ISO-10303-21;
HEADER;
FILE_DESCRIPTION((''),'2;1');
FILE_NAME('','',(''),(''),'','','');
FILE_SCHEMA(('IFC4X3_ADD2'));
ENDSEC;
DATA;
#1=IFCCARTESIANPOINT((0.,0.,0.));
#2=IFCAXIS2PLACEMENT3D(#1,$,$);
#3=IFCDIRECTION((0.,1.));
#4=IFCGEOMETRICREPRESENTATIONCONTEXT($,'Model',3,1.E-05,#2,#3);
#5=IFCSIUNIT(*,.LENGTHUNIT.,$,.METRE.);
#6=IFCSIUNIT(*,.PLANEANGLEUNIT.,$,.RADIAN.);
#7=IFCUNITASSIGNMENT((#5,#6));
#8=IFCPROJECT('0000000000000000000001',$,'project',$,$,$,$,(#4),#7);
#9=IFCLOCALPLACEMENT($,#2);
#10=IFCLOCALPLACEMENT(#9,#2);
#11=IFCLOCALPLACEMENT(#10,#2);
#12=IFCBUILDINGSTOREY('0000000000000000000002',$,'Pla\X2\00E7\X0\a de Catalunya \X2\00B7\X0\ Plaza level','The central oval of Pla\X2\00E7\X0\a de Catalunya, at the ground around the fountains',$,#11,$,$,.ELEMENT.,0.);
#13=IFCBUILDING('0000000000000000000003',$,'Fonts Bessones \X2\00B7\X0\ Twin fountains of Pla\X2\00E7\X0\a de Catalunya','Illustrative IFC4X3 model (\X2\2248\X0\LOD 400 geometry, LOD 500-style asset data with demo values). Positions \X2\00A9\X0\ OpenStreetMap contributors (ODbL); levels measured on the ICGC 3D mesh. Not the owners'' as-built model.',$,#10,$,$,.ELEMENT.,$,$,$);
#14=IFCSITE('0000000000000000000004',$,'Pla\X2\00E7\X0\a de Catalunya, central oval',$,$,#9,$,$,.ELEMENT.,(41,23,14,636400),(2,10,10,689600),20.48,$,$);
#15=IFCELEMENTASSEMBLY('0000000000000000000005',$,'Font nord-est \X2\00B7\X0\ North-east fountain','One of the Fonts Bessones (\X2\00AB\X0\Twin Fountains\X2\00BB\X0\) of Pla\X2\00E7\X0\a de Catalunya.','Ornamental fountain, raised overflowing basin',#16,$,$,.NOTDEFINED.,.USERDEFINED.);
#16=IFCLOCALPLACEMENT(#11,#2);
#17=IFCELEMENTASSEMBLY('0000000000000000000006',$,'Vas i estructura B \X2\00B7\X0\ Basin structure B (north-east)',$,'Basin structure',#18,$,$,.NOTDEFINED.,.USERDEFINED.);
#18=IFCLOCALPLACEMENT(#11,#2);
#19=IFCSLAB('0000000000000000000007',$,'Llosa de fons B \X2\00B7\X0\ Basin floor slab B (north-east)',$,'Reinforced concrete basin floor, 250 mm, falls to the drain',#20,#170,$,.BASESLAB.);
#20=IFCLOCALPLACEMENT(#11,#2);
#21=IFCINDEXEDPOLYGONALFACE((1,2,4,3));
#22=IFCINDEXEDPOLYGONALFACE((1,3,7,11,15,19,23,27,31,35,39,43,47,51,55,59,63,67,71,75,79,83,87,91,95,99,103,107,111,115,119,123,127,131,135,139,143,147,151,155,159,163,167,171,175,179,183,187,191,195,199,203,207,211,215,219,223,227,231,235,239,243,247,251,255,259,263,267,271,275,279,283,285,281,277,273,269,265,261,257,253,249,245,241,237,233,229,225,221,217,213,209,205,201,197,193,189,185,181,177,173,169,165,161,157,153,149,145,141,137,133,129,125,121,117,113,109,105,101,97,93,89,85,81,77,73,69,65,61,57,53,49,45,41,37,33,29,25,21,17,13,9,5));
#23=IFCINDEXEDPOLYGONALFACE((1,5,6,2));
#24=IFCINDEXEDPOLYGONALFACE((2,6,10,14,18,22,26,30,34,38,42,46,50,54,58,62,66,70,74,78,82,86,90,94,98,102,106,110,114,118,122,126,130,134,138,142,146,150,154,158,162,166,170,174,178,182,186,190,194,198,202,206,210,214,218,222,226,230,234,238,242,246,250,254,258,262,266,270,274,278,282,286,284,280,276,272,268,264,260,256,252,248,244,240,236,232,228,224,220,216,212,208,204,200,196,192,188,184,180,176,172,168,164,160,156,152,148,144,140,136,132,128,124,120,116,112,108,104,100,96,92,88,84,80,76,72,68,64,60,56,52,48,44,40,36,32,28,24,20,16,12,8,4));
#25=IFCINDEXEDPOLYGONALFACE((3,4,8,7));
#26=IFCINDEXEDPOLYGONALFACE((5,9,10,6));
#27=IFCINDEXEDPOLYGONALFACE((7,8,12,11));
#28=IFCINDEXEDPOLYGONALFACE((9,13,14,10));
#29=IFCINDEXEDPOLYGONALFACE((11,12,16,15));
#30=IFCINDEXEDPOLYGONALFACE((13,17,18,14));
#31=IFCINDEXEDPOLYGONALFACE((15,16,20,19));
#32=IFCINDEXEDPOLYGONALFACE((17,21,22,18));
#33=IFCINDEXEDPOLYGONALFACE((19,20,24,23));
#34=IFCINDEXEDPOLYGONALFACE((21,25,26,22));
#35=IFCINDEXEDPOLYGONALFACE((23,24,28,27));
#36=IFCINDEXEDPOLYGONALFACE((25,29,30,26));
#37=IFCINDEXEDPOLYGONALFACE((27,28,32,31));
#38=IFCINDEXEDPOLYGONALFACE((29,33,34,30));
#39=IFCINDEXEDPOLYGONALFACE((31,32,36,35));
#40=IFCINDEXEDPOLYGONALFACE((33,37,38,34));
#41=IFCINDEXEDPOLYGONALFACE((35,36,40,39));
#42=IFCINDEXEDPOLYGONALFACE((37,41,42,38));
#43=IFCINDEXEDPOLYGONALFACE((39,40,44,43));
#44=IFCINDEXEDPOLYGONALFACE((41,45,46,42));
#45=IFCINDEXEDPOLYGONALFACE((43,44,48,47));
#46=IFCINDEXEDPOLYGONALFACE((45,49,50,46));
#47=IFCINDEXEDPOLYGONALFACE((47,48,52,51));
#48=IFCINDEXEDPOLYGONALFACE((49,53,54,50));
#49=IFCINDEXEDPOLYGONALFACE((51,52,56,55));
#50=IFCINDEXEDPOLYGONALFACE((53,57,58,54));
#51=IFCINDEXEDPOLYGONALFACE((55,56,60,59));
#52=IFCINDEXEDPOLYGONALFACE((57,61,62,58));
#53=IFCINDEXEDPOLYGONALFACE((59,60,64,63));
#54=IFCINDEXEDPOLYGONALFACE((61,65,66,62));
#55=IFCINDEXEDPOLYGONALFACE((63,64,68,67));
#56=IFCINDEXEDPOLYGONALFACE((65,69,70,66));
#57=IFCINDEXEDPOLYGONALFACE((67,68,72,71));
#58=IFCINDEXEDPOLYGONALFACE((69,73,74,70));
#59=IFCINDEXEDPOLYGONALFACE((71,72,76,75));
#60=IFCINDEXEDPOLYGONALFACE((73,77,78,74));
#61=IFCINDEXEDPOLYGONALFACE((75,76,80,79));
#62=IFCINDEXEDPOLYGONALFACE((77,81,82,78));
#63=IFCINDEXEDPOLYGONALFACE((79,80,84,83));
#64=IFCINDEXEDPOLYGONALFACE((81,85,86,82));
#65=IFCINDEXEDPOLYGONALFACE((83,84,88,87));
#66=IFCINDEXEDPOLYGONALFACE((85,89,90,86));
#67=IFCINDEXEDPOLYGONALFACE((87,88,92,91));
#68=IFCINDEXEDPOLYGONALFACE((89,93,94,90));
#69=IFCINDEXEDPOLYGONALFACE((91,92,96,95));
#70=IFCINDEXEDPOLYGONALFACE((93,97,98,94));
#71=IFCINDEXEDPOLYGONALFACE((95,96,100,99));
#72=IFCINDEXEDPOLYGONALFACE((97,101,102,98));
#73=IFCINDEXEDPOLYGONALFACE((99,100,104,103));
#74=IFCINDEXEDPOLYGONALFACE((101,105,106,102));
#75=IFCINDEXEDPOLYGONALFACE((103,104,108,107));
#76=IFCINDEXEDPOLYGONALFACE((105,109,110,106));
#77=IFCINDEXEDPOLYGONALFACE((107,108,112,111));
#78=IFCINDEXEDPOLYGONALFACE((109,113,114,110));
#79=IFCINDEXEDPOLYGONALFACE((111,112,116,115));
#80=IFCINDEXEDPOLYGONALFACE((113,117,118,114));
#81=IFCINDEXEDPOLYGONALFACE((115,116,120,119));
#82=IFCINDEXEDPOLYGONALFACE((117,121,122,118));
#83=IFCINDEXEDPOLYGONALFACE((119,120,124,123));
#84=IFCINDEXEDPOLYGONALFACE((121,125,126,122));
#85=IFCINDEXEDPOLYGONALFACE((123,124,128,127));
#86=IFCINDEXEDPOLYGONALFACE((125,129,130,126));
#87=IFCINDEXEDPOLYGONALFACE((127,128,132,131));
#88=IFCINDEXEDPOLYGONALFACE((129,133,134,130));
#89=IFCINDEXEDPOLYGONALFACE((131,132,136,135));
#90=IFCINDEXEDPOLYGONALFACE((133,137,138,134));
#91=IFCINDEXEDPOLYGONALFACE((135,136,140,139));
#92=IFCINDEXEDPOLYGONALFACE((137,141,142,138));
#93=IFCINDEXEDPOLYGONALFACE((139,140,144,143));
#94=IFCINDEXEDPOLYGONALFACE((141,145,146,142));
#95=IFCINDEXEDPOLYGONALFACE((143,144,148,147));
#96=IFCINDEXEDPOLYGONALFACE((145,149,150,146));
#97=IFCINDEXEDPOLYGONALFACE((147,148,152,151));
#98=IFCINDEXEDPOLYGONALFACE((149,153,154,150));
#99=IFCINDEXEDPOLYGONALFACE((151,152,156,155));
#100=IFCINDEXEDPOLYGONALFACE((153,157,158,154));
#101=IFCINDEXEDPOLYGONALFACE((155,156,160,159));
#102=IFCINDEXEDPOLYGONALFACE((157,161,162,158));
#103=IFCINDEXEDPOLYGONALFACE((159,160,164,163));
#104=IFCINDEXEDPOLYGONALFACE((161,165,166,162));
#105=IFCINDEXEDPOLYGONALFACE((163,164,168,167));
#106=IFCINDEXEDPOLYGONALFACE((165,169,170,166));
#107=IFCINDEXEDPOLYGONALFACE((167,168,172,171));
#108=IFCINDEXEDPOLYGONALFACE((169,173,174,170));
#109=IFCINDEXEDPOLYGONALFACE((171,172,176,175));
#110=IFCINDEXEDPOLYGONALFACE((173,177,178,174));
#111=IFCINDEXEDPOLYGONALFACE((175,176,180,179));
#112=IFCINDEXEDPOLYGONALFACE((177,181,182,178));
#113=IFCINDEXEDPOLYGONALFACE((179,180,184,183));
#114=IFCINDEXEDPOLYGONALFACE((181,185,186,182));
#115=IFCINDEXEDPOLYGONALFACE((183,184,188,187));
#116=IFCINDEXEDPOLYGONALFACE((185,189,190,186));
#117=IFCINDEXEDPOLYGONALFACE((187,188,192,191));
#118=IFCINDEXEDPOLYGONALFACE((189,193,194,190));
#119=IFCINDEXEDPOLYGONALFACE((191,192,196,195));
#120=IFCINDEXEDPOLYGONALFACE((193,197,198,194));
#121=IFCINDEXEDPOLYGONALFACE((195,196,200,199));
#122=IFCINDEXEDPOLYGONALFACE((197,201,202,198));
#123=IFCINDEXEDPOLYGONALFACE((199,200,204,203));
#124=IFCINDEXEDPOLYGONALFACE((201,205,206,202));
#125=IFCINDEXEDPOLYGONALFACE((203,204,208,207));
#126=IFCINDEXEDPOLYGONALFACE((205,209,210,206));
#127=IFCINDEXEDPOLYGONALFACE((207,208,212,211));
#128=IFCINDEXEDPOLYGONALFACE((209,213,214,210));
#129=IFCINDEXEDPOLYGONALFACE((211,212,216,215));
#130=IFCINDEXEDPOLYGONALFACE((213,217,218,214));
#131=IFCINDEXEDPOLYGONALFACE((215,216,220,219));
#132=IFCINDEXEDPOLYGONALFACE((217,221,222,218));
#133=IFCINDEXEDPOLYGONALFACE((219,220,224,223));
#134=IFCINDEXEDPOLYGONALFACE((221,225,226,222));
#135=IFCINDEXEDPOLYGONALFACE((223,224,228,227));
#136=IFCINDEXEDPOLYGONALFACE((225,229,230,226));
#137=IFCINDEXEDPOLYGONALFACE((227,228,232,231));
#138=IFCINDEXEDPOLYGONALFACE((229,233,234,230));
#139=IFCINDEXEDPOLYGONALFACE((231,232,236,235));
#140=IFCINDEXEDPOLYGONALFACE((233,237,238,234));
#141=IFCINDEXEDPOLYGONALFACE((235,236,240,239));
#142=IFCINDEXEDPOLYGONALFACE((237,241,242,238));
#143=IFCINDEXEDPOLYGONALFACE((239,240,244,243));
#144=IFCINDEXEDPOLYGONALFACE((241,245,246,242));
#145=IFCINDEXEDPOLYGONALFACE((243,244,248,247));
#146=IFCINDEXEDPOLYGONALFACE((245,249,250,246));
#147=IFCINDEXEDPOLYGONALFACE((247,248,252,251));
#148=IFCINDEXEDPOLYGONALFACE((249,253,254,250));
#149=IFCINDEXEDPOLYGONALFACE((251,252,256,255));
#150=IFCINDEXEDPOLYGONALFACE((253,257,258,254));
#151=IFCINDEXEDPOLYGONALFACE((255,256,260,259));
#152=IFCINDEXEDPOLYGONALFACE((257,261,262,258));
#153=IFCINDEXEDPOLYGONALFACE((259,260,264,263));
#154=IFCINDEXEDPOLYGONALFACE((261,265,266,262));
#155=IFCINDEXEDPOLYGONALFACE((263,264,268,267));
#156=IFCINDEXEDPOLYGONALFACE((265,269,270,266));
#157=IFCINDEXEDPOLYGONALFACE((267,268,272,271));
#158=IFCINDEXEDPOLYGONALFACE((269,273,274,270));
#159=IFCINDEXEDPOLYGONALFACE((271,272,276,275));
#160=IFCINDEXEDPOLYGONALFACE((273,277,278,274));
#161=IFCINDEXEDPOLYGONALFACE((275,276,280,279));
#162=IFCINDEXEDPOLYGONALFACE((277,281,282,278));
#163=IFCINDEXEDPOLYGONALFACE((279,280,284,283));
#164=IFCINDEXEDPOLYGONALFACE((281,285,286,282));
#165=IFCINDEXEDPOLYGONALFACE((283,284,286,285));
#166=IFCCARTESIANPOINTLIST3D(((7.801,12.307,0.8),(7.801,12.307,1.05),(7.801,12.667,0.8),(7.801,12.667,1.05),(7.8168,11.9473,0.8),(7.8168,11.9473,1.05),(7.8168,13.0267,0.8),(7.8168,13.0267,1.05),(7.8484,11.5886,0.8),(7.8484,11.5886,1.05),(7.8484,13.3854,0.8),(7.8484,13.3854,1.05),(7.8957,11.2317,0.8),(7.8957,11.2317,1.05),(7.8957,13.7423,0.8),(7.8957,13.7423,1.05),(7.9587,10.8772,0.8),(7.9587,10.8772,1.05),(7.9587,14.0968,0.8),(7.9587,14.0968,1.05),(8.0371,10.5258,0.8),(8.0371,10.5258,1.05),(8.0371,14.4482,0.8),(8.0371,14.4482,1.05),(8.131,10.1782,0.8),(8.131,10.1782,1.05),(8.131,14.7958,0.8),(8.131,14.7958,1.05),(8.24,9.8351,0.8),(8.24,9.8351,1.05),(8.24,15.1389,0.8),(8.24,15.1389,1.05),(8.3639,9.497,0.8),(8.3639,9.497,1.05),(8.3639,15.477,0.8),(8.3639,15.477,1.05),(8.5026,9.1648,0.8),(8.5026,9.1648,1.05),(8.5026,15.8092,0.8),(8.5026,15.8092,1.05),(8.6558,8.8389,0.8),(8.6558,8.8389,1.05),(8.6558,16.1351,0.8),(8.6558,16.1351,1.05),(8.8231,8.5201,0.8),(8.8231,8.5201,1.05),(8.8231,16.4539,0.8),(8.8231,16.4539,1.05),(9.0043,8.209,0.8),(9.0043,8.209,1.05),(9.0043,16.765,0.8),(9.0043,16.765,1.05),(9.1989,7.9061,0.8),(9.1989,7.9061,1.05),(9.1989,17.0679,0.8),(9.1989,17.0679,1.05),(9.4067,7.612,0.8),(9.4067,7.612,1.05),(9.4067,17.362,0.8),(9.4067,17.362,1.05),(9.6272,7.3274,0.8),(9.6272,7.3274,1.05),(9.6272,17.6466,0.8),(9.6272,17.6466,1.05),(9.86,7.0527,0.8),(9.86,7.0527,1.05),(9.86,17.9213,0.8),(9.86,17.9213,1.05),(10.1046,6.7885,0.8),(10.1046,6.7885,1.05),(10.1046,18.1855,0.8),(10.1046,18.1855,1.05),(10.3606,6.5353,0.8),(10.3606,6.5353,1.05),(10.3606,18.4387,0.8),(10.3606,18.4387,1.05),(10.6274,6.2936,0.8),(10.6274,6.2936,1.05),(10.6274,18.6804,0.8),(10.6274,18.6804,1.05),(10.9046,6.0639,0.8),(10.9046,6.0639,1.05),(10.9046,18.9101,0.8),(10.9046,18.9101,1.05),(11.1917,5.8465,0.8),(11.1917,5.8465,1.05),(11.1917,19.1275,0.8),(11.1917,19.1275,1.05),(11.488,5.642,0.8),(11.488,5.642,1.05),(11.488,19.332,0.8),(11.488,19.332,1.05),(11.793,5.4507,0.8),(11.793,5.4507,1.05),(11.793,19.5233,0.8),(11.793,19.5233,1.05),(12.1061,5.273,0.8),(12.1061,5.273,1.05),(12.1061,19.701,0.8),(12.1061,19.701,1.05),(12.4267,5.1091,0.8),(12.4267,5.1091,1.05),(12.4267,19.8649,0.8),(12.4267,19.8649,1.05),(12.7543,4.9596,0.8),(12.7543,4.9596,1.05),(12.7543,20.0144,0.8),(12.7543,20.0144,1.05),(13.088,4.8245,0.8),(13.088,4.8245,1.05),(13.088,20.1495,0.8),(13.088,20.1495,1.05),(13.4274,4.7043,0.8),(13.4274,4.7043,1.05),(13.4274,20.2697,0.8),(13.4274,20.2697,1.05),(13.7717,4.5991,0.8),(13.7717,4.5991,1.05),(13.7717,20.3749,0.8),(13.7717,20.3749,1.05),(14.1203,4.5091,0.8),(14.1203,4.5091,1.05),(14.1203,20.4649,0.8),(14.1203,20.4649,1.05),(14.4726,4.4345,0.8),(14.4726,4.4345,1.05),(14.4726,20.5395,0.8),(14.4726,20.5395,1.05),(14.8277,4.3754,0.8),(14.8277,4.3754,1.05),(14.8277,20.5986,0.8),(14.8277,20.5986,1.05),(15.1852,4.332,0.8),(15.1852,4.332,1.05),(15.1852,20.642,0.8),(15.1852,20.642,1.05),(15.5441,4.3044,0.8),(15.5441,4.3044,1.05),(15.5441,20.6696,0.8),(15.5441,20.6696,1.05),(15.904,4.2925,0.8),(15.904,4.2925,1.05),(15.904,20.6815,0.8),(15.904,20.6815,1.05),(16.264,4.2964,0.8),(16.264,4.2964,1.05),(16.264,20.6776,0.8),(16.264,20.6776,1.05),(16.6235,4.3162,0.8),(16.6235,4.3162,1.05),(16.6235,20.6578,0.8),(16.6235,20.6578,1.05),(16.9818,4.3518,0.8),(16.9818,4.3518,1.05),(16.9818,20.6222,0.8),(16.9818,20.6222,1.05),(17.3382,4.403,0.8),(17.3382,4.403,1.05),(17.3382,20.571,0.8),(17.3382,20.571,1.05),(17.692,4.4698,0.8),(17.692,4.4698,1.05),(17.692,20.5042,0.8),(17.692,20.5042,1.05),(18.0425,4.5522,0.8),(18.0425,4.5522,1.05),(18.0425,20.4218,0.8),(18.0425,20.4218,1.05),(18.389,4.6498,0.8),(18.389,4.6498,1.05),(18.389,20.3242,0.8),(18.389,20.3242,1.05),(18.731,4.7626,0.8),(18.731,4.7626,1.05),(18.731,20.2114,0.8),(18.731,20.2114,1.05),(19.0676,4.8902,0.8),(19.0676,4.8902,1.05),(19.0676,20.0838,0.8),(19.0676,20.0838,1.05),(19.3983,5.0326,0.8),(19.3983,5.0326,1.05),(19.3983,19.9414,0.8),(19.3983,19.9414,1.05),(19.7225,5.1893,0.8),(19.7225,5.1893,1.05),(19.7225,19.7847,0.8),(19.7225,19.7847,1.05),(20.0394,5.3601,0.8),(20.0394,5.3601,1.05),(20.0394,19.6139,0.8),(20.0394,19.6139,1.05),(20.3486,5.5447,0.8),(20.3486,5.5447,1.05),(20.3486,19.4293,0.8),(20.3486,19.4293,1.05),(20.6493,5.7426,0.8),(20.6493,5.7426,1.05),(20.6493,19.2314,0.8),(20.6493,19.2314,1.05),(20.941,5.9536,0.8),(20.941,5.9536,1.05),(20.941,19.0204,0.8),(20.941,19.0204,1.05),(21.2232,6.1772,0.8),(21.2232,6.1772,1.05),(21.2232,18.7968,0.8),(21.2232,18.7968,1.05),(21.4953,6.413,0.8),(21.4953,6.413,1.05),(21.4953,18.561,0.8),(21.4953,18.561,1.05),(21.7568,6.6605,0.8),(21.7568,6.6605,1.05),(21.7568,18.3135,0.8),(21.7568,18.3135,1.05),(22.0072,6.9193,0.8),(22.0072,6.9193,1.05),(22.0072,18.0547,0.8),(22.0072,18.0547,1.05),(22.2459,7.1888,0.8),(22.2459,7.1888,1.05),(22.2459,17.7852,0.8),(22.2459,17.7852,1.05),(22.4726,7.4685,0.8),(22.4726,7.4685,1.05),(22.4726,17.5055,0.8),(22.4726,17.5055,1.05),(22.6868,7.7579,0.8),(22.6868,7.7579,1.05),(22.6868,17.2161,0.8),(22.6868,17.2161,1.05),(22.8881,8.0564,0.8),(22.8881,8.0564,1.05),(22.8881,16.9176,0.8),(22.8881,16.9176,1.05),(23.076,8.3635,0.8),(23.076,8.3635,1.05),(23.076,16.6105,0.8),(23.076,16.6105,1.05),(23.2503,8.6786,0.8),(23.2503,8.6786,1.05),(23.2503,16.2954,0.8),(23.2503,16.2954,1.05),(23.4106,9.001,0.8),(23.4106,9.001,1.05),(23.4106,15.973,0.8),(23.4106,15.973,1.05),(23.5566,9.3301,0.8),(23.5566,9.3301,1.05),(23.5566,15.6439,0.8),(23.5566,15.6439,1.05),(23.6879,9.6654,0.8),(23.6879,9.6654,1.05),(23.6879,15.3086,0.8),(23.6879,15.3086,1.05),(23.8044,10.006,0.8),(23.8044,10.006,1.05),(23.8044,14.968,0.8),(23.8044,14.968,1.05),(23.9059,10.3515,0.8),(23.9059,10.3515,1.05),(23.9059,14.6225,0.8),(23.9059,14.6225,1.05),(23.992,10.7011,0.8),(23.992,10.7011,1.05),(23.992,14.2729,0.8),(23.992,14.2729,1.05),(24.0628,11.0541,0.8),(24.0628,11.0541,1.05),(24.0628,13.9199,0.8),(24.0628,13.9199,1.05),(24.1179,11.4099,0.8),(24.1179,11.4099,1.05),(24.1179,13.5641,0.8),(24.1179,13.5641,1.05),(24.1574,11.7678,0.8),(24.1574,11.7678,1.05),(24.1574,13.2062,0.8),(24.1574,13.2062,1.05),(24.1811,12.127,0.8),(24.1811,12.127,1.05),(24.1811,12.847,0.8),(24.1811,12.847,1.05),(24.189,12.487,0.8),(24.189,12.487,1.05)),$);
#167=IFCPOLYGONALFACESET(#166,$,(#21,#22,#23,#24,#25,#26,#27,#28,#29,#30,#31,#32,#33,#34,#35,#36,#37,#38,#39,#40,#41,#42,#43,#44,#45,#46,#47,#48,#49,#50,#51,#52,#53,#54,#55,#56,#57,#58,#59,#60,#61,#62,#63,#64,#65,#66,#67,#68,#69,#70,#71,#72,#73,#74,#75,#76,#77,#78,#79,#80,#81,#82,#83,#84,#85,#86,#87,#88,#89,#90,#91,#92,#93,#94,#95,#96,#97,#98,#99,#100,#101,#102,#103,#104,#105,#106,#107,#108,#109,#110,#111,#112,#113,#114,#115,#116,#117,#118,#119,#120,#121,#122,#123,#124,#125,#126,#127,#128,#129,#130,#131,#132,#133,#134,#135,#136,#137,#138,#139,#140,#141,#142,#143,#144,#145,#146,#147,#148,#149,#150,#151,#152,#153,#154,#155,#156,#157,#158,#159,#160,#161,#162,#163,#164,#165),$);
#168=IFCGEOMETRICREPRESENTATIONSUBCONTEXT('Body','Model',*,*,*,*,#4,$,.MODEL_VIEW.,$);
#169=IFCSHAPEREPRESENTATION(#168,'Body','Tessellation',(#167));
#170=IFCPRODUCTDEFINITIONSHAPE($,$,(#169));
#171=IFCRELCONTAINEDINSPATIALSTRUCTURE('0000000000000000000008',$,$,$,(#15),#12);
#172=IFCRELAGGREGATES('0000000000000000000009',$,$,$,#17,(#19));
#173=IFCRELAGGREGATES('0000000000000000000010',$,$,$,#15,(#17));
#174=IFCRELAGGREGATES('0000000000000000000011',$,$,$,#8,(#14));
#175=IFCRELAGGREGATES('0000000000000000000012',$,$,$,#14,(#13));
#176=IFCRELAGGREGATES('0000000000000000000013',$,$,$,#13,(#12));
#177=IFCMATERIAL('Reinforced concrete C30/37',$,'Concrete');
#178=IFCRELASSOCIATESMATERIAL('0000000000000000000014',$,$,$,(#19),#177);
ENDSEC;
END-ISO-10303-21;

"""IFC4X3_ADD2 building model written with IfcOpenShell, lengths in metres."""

from ifc_helpers import new_model, si_unit, direction, frame, origin, origin_2d_with_axis, place, context, subcontext, project, spatial, circle, extrude, material, element, aggregate, save


model = new_model("IFC4X3_ADD2")

# Units and contexts
model_context = context("Model", 3, precision=1e-05, world=origin(), true_north=direction((0.0, 1.0)))
body_context = subcontext(model_context, "Body", "Model", "MODEL_VIEW")
ifc_project = project(units=[si_unit("LENGTHUNIT", "METRE"), si_unit("PLANEANGLEUNIT", "RADIAN")], contexts=[model_context])

# Site, building, storey
site_placement = place(None, origin())
site = spatial("IfcSite", under=ifc_project, at=site_placement, Name="Plaça de Catalunya, central oval", CompositionType="ELEMENT", RefLatitude=(41, 23, 14, 636400), RefLongitude=(2, 10, 10, 689600), RefElevation=20.48)
building_placement = place(site_placement, origin())
building = spatial("IfcBuilding", under=site, at=building_placement, Name="Fonts Bessones · Twin fountains of Plaça de Catalunya", Description="Illustrative IFC4X3 model (≈LOD 400 geometry, LOD 500-style asset data with demo values). Positions © OpenStreetMap contributors (ODbL); levels measured on the ICGC 3D mesh. Not the owners' as-built model.", CompositionType="ELEMENT")
storey_placement = place(building_placement, origin())
storey = spatial("IfcBuildingStorey", under=building, at=storey_placement, Name="Plaça de Catalunya · Plaza level", Description="The central oval of Plaça de Catalunya, at the ground around the fountains", CompositionType="ELEMENT", Elevation=0.0)

# Element assemblies
assembly_1_placement = place(building_placement, origin())
assembly_1 = element("IfcElementAssembly", 1, at=assembly_1_placement, inside=storey, Name="Font nord-est · North-east fountain", Description="One of the Fonts Bessones («Twin Fountains») of Plaça de Catalunya.", ObjectType="Ornamental fountain, raised overflowing basin", AssemblyPlace="NOTDEFINED", PredefinedType="USERDEFINED")
assembly_2_placement = place(building_placement, origin())
assembly_2 = element("IfcElementAssembly", 2, at=assembly_2_placement, Name="Vas i estructura B · Basin structure B (north-east)", ObjectType="Basin structure", AssemblyPlace="NOTDEFINED", PredefinedType="USERDEFINED")
ifc_material_1 = material(Name="Reinforced concrete C30/37", Category="Concrete")

# Slab
slab_1_placement = place(building_placement, origin())
slab_1 = element("IfcSlab", 3, at=slab_1_placement, material=ifc_material_1, Name="Llosa de fons B · Basin floor slab B (north-east)", ObjectType="Reinforced concrete basin floor, 250 mm, falls to the drain", PredefinedType="BASESLAB", context=body_context, shape_type="SweptSolid", body=[
    extrude(circle(Radius=8.195, at=origin_2d_with_axis()), frame((15.994, 12.487, 0.8)), (0.0, 0.0, 1.0), 0.25),
])

aggregate(assembly_2, [slab_1])

aggregate(assembly_1, [assembly_2])

save(model, "model.ifc")
